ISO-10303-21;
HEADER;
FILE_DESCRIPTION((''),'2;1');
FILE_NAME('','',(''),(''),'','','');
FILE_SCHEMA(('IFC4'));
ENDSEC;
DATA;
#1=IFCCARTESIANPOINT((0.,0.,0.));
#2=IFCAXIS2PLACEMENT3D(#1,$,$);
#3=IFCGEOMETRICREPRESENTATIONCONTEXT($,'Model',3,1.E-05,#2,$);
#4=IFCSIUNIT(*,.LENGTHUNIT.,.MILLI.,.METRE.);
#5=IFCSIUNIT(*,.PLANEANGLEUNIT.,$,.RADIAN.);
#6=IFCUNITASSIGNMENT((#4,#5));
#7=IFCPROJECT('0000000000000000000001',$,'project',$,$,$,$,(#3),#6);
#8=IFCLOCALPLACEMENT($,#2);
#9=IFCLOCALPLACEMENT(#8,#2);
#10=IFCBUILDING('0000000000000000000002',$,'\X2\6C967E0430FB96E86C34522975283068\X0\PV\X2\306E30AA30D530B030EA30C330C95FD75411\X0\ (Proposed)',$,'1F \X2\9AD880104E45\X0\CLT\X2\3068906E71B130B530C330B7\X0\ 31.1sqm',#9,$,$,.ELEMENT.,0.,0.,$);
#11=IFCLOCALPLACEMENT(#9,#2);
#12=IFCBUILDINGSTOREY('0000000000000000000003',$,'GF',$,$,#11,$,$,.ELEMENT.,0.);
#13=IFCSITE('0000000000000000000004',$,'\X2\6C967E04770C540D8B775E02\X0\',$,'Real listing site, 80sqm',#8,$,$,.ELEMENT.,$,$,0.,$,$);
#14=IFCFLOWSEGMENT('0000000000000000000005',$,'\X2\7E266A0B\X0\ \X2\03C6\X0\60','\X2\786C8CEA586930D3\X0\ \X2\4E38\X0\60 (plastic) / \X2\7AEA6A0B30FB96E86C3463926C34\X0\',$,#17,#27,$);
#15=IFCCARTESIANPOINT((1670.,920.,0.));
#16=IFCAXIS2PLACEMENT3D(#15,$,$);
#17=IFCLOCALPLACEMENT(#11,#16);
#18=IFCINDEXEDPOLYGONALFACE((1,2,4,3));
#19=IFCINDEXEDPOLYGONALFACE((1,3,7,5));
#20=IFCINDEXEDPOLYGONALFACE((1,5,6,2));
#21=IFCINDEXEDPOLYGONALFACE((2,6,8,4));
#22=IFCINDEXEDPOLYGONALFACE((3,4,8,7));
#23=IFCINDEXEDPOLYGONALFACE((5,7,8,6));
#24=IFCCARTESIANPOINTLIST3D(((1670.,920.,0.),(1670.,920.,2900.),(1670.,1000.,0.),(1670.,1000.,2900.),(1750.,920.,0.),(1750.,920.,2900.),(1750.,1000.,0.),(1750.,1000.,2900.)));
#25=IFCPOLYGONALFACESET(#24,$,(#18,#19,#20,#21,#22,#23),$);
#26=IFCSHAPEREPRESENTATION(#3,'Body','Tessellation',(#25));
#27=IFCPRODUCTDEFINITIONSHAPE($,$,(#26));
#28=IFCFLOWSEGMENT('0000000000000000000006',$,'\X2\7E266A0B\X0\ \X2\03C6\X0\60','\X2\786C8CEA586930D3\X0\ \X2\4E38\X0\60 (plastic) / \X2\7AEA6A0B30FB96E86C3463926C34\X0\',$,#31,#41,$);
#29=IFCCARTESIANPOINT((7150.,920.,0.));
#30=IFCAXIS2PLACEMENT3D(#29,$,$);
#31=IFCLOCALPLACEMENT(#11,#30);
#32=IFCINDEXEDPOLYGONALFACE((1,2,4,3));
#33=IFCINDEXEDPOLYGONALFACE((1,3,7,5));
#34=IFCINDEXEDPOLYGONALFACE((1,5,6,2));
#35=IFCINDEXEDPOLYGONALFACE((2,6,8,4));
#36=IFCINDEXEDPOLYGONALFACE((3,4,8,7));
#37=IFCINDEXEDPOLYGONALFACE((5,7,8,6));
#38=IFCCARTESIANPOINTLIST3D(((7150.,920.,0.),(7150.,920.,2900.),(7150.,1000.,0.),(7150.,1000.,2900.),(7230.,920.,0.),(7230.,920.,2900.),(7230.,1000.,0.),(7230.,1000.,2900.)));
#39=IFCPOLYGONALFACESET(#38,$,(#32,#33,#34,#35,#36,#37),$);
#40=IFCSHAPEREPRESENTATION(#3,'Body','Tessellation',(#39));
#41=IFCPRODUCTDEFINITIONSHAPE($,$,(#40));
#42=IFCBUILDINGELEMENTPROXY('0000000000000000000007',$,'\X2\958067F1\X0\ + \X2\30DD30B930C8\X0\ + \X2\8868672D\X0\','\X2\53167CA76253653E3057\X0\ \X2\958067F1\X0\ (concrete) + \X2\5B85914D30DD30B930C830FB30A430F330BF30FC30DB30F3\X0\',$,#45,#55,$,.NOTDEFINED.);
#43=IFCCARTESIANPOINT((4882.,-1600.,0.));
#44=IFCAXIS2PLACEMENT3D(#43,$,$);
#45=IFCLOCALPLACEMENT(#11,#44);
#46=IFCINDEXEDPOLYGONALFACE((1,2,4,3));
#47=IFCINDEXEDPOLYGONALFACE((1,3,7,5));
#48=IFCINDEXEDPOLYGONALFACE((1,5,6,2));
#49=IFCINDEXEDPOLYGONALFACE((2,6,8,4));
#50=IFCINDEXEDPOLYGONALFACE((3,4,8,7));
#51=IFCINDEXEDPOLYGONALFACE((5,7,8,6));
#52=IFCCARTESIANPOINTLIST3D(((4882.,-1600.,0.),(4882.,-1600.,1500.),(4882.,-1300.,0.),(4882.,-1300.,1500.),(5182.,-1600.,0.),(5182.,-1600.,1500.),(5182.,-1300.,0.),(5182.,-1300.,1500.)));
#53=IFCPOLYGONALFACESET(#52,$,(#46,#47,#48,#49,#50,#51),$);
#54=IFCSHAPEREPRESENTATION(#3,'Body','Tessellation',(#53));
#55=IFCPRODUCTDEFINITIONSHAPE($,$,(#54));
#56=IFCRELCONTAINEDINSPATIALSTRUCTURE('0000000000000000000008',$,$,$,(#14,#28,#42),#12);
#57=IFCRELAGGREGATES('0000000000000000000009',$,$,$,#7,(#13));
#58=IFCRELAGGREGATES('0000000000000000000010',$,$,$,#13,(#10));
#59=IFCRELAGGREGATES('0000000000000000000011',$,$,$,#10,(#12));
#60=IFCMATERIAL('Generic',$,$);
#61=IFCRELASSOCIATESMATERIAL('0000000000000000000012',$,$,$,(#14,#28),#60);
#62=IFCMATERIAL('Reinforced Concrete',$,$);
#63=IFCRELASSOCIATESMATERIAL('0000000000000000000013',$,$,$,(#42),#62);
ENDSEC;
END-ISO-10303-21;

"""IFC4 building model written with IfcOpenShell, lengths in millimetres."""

from ifc_helpers import new_model, si_unit, frame, frame_2d, origin, place, context, project, spatial, rectangle, extrude, material, element, save


model = new_model("IFC4")

# Units and contexts
model_context = context("Model", 3, precision=1e-05, world=origin())
ifc_project = project(units=[si_unit("LENGTHUNIT", "METRE", prefix="MILLI"), si_unit("PLANEANGLEUNIT", "RADIAN")], contexts=[model_context])

# Site, building, storey
site_placement = place(None, origin())
site = spatial("IfcSite", under=ifc_project, at=site_placement, Name="沖縄県名護市", ObjectType="Real listing site, 80sqm", CompositionType="ELEMENT", RefElevation=0.0)
building_placement = place(site_placement, origin())
building = spatial("IfcBuilding", under=site, at=building_placement, Name="沖縄・雨水利用とPVのオフグリッド志向 (Proposed)", ObjectType="1F 高耐久CLTと遮熱サッシ 31.1sqm", CompositionType="ELEMENT", ElevationOfRefHeight=0.0, ElevationOfTerrain=0.0)
storey_placement = place(building_placement, origin())
storey = spatial("IfcBuildingStorey", under=building, at=storey_placement, Name="GF", CompositionType="ELEMENT", Elevation=0.0)

# Shared definitions
ifc_material_1 = material(Name="Reinforced Concrete")

# Shared definitions
ifc_material_2 = material(Name="Generic")

# Flow segments
flow_segment_1_placement = place(storey_placement, frame((1670.0, 920.0, 0.0)))
element("IfcFlowSegment", 1, at=flow_segment_1_placement, inside=storey, material=ifc_material_2, Name="縦樋 φ60", Description="硬質塩ビ 丸60 (plastic) / 竪樋・雨水排水", context=model_context, shape_type="SweptSolid", body=[
    extrude(rectangle(XDim=80.0, YDim=80.0, at=frame_2d((40.0, 40.0))), frame((1670.0, 920.0, 0.0)), (0.0, 0.0, 1.0), 2900.0),
])
flow_segment_2_placement = place(storey_placement, frame((7150.0, 920.0, 0.0)))
element("IfcFlowSegment", 2, at=flow_segment_2_placement, inside=storey, material=ifc_material_2, Name="縦樋 φ60", Description="硬質塩ビ 丸60 (plastic) / 竪樋・雨水排水", context=model_context, shape_type="SweptSolid", body=[
    extrude(rectangle(XDim=80.0, YDim=80.0, at=frame_2d((40.0, 40.0))), frame((7150.0, 920.0, 0.0)), (0.0, 0.0, 1.0), 2900.0),
])

# Building element proxy
proxy_placement = place(storey_placement, frame((4882.0, -1600.0, 0.0)))
element("IfcBuildingElementProxy", 3, at=proxy_placement, inside=storey, material=ifc_material_1, Name="門柱 + ポスト + 表札", Description="化粧打放し 門柱 (concrete) + 宅配ポスト・インターホン", PredefinedType="NOTDEFINED", context=model_context, shape_type="SweptSolid", body=[
    extrude(rectangle(XDim=300.0, YDim=300.0, at=frame_2d((150.0, 150.0))), frame((4882.0, -1600.0, 0.0)), (0.0, 0.0, 1.0), 1500.0),
])

save(model, "model.ifc")
